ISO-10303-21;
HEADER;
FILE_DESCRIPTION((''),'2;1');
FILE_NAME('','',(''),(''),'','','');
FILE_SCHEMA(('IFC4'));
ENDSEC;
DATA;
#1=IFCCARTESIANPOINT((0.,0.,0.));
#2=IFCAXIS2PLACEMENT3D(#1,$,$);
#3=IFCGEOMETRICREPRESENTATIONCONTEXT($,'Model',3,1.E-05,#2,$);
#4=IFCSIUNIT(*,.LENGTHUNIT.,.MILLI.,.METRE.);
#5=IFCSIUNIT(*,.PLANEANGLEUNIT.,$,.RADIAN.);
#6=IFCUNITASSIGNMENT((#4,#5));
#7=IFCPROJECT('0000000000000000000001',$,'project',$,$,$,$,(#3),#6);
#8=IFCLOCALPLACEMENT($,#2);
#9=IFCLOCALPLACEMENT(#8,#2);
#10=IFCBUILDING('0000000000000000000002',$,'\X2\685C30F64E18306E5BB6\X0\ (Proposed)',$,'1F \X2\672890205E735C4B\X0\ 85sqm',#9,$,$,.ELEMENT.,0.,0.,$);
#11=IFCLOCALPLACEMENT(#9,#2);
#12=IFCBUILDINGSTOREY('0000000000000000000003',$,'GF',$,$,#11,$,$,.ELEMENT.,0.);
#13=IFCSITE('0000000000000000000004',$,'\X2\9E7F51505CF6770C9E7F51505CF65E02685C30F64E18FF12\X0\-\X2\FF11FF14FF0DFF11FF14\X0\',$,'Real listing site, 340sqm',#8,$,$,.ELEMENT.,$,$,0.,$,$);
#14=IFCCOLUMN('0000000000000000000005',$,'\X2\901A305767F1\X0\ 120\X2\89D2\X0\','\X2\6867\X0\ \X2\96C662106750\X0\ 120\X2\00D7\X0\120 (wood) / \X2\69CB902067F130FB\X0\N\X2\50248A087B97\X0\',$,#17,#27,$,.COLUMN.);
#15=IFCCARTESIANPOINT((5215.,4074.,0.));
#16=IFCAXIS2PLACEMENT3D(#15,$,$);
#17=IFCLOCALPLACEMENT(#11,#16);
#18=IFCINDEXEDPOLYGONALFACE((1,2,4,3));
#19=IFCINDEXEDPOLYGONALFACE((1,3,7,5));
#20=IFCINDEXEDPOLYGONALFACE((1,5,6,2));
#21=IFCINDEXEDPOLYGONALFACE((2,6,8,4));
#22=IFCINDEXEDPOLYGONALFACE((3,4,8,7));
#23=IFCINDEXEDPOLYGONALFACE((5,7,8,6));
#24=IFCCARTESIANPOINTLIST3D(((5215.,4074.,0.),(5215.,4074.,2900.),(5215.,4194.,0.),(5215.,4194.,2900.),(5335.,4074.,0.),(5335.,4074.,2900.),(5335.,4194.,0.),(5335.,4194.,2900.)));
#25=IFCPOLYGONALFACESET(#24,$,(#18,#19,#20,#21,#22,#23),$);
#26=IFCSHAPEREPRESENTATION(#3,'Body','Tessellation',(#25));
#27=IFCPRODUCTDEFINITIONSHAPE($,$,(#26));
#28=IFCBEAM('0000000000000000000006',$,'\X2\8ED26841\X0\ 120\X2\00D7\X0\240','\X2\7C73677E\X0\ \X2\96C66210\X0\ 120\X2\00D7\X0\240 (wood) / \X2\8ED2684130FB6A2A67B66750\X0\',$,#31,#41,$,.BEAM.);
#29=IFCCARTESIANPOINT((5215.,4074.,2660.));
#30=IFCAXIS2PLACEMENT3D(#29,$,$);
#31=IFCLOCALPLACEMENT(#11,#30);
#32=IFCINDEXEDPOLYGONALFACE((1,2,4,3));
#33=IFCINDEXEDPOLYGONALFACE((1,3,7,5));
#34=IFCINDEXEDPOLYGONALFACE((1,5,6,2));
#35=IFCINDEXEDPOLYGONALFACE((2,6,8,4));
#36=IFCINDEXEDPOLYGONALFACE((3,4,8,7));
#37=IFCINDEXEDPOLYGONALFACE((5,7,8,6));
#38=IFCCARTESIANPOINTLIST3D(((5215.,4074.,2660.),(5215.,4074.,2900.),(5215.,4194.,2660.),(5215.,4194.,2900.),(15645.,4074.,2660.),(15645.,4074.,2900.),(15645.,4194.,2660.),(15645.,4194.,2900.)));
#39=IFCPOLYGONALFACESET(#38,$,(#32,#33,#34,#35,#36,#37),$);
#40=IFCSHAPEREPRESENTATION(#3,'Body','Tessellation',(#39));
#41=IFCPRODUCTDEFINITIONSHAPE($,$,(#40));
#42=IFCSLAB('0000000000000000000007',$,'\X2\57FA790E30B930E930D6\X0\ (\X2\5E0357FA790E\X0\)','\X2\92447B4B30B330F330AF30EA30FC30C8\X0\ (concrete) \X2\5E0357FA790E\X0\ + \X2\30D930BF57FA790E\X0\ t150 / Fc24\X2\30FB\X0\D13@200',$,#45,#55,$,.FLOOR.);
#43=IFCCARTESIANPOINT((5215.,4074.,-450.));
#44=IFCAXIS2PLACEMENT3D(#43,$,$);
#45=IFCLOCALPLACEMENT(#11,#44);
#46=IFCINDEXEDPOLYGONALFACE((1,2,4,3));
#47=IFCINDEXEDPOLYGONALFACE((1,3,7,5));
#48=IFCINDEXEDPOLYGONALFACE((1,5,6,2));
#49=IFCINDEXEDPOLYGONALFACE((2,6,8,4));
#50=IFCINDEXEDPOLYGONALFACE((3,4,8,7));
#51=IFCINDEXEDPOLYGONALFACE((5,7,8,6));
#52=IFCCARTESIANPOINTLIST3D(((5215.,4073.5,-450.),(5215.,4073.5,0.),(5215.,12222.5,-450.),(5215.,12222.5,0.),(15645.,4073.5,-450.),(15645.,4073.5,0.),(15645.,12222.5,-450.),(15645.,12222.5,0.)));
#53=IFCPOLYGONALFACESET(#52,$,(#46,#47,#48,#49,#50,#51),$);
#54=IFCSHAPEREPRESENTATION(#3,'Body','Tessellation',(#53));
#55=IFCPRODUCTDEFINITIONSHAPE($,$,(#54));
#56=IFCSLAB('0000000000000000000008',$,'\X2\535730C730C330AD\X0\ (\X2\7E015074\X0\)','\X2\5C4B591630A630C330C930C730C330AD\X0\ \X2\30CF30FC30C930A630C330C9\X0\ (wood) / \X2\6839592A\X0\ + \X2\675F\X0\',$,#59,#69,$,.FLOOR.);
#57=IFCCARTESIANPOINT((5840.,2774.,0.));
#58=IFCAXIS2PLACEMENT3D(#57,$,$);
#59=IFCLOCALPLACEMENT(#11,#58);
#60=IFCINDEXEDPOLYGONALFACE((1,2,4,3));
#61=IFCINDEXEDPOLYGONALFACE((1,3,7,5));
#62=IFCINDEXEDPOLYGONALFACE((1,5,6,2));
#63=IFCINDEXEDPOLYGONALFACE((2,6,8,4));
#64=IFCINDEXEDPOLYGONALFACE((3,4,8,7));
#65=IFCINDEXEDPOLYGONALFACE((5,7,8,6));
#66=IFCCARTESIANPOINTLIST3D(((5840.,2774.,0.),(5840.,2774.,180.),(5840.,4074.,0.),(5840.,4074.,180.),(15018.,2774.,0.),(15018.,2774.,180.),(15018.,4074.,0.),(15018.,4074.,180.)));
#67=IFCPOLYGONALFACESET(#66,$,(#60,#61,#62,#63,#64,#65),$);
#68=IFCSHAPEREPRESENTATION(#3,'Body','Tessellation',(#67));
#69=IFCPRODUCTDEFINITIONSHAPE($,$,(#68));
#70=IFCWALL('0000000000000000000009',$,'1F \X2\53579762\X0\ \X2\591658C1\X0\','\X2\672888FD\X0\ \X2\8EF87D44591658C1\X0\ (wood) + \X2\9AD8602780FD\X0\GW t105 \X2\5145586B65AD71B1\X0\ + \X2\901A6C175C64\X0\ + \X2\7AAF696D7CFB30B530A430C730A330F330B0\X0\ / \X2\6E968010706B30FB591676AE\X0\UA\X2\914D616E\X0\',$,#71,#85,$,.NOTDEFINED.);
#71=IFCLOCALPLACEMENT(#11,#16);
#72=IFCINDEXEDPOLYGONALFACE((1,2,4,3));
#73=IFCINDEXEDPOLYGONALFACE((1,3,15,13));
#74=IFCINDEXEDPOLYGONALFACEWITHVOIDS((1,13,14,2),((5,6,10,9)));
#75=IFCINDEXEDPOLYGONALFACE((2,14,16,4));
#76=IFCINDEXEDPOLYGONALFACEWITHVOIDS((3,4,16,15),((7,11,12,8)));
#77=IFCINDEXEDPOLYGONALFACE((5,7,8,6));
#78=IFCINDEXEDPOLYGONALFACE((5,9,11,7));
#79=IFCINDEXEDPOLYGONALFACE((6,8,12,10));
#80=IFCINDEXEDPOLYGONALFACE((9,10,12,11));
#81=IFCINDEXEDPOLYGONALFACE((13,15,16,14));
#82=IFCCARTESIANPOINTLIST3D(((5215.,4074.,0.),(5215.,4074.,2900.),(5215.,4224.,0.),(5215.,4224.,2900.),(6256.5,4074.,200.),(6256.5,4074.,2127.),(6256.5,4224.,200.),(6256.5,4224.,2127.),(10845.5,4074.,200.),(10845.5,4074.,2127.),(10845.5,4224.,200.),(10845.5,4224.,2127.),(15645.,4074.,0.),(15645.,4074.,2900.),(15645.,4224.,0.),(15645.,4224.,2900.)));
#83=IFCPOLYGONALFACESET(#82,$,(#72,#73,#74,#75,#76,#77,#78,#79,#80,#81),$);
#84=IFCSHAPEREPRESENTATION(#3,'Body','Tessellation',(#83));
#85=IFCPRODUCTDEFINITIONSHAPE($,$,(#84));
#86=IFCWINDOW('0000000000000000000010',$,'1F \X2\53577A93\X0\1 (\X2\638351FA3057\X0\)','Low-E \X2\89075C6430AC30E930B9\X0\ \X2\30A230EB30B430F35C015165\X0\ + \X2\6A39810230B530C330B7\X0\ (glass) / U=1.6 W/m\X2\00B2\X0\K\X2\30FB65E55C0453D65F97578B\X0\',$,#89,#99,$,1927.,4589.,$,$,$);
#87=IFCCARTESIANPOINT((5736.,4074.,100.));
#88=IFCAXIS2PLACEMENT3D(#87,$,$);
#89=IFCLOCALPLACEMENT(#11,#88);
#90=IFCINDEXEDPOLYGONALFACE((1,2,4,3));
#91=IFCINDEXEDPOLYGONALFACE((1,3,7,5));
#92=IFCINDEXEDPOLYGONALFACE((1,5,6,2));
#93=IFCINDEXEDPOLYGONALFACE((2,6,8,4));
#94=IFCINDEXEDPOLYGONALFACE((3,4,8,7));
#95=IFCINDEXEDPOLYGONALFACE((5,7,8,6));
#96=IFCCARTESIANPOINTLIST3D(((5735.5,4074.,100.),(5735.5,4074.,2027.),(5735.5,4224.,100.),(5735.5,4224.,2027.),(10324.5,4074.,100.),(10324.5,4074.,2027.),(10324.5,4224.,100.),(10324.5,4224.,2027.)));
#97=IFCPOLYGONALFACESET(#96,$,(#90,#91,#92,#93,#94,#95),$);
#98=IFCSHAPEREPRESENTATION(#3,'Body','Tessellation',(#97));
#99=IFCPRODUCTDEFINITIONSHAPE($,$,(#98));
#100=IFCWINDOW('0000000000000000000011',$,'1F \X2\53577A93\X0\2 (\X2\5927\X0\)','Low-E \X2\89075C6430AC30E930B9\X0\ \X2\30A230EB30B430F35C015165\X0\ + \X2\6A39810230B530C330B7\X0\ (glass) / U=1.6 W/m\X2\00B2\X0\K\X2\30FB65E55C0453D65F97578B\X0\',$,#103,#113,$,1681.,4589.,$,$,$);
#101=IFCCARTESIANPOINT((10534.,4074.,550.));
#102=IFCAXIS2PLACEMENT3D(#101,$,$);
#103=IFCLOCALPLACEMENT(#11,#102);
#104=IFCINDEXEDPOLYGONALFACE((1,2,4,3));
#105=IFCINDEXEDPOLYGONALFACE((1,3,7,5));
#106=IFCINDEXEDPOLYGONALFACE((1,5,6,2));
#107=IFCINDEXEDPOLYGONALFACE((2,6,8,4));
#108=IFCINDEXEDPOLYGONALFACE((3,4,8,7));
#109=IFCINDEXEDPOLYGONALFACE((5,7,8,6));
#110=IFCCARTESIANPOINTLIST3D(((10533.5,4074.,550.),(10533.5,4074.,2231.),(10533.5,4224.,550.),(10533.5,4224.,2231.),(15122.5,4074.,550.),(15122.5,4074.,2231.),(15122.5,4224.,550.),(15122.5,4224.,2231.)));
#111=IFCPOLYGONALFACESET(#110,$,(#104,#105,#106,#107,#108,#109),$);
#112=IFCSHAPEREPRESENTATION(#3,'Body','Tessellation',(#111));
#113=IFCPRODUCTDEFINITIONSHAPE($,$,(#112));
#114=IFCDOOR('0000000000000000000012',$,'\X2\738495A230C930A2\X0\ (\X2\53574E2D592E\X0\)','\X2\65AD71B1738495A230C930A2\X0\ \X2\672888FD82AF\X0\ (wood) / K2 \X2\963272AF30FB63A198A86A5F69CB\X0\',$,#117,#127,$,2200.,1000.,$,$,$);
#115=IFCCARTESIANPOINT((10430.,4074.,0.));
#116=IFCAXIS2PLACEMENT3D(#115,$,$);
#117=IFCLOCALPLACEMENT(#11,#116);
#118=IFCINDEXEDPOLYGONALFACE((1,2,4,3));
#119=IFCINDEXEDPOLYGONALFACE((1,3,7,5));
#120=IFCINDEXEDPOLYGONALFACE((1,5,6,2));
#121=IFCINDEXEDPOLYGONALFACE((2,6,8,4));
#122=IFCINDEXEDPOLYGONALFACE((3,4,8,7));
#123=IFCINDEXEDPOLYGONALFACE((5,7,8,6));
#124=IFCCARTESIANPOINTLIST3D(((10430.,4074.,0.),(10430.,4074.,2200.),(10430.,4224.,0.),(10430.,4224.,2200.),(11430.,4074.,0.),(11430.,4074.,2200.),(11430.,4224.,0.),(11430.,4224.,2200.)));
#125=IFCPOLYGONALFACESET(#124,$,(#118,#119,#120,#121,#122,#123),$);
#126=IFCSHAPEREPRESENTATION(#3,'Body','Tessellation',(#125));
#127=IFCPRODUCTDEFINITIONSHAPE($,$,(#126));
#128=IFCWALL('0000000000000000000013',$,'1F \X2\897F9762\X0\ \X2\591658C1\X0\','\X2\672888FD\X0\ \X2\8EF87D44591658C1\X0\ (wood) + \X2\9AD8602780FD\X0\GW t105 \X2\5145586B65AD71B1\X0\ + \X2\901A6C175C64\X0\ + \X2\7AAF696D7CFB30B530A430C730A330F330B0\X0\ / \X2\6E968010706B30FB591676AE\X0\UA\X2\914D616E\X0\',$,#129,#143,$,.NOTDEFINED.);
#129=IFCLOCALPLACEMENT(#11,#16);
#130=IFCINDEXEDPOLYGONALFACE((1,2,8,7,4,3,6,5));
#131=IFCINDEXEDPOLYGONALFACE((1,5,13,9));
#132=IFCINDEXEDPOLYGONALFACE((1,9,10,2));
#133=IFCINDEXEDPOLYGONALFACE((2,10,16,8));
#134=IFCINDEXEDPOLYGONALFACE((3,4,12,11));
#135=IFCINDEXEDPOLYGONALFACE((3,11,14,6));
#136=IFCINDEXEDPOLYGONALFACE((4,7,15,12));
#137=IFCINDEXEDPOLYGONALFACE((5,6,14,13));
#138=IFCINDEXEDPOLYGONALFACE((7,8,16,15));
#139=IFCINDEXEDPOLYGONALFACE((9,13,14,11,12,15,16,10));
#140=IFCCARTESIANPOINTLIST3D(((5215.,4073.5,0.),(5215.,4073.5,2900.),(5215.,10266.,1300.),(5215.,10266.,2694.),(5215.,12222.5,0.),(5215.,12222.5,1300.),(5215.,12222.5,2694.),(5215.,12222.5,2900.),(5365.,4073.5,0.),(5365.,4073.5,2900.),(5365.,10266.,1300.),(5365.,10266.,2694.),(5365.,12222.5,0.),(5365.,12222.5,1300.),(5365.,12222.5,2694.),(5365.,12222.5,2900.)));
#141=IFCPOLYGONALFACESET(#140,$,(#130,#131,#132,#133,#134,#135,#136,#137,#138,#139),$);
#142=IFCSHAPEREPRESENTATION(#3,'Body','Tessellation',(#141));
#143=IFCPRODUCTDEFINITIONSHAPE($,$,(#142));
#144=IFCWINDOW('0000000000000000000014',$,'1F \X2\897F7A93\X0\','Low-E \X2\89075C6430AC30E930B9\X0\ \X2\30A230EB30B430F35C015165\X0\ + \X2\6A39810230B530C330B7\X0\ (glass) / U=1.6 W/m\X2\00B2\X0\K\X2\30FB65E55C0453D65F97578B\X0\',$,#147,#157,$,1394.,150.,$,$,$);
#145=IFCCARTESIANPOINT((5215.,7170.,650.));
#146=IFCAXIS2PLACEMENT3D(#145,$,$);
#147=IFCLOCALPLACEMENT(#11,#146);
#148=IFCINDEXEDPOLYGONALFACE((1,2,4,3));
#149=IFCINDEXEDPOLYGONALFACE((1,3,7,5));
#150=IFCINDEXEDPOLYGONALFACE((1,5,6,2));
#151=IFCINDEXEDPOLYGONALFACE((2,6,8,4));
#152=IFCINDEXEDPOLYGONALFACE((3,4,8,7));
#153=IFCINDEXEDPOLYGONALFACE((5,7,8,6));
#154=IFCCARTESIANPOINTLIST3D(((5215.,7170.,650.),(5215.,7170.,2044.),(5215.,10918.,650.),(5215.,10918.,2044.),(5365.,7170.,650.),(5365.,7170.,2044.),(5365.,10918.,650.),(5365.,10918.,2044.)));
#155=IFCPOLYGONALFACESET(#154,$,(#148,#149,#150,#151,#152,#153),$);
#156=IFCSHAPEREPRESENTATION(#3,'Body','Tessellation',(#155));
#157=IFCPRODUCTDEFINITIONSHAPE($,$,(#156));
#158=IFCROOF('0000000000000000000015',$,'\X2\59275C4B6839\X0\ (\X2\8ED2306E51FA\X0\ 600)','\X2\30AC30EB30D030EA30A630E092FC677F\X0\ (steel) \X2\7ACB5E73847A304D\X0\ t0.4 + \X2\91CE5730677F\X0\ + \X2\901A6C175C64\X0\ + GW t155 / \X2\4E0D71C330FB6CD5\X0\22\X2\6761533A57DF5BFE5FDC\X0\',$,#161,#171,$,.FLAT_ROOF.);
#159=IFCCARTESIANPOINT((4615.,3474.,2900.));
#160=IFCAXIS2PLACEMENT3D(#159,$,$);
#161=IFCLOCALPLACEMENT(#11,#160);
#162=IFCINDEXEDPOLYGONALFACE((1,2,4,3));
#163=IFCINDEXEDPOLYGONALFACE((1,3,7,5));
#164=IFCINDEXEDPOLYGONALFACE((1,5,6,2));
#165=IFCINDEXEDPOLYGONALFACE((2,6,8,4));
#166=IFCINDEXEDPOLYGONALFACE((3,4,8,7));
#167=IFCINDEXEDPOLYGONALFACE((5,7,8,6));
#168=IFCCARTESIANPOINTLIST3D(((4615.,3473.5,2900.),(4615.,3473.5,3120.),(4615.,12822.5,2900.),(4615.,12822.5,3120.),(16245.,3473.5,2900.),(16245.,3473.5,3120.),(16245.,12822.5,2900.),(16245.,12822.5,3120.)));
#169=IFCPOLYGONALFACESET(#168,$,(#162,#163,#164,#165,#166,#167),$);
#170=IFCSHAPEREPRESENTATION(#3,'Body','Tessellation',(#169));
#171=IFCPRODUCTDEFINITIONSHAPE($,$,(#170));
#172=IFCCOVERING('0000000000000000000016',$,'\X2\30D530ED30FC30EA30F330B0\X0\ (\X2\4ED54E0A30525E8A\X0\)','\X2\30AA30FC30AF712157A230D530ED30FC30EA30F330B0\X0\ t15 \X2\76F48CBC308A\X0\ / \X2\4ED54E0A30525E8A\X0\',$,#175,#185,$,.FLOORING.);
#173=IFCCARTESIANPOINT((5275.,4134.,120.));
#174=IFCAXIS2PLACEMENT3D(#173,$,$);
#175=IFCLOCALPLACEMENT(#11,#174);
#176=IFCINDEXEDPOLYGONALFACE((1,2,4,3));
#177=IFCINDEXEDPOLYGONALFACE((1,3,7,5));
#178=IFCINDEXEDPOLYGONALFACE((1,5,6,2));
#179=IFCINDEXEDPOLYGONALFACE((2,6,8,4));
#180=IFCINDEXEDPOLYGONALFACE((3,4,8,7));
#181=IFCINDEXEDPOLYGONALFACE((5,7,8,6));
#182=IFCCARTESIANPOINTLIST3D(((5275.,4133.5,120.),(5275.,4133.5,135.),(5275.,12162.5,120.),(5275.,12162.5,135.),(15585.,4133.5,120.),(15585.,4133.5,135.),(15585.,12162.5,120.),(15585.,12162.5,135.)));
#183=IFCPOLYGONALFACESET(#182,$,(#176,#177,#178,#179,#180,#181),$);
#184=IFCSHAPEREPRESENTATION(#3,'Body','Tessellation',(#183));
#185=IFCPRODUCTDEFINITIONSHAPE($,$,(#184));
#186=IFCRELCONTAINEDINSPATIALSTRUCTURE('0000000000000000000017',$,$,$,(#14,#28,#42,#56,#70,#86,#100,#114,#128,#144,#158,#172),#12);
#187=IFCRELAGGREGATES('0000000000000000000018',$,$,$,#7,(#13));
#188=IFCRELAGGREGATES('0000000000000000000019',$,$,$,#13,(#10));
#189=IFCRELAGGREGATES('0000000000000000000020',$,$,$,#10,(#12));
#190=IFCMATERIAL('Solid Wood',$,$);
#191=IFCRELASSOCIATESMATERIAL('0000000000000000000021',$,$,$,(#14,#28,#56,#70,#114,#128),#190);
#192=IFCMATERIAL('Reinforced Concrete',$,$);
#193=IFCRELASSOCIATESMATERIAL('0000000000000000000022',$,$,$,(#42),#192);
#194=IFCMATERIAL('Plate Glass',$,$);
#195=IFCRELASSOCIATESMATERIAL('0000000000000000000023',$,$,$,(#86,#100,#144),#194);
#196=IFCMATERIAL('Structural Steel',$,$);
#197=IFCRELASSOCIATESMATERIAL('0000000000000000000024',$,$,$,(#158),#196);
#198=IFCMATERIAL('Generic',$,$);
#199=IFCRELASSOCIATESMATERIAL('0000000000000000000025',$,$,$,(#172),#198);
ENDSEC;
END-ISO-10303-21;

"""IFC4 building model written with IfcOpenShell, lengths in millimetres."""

from ifc_helpers import new_model, si_unit, frame, frame_2d, origin, place, context, project, spatial, rectangle, extrude, material, element, fill, save


model = new_model("IFC4")

# Units and contexts
model_context = context("Model", 3, precision=1e-05, world=origin())
ifc_project = project(units=[si_unit("LENGTHUNIT", "METRE", prefix="MILLI"), si_unit("PLANEANGLEUNIT", "RADIAN")], contexts=[model_context])

# Site, building, storey
site_placement = place(None, origin())
site = spatial("IfcSite", under=ifc_project, at=site_placement, Name="鹿児島県鹿児島市桜ヶ丘２-１４－１４", ObjectType="Real listing site, 340sqm", CompositionType="ELEMENT", RefElevation=0.0)
building_placement = place(site_placement, origin())
building = spatial("IfcBuilding", under=site, at=building_placement, Name="桜ヶ丘の家 (Proposed)", ObjectType="1F 木造平屋 85sqm", CompositionType="ELEMENT", ElevationOfRefHeight=0.0, ElevationOfTerrain=0.0)
storey_placement = place(building_placement, origin())
storey = spatial("IfcBuildingStorey", under=building, at=storey_placement, Name="GF", CompositionType="ELEMENT", Elevation=0.0)

# Column
ifc_material_1 = material(Name="Solid Wood")
column_1_placement = place(storey_placement, frame((5215.0, 4074.0, 0.0)))
element("IfcColumn", 1, at=column_1_placement, inside=storey, material=ifc_material_1, Name="通し柱 120角", Description="桧 集成材 120×120 (wood) / 構造柱・N値計算", PredefinedType="COLUMN", context=model_context, shape_type="SweptSolid", body=[
    extrude(rectangle(XDim=120.0, YDim=120.0, at=frame_2d((60.0, 60.0))), frame((5215.0, 4074.0, 0.0)), (0.0, 0.0, 1.0), 2900.0),
])

# Beam
beam_1_placement = place(storey_placement, frame((5215.0, 4074.0, 2660.0)))
element("IfcBeam", 2, at=beam_1_placement, inside=storey, material=ifc_material_1, Name="軒桁 120×240", Description="米松 集成 120×240 (wood) / 軒桁・横架材", PredefinedType="BEAM", context=model_context, shape_type="SweptSolid", body=[
    extrude(rectangle(XDim=10430.0, YDim=120.0, at=frame_2d((5215.0, 60.0))), frame((5215.0, 4074.0, 2660.0)), (0.0, 0.0, 1.0), 240.0),
])

# Slabs
ifc_material_2 = material(Name="Reinforced Concrete")
slab_1_placement = place(storey_placement, frame((5215.0, 4074.0, -450.0)))
element("IfcSlab", 3, at=slab_1_placement, inside=storey, material=ifc_material_2, Name="基礎スラブ (布基礎)", Description="鉄筋コンクリート (concrete) 布基礎 + ベタ基礎 t150 / Fc24・D13@200", PredefinedType="FLOOR", context=model_context, shape_type="SweptSolid", body=[
    extrude(rectangle(XDim=10430.0, YDim=8149.0, at=frame_2d((5215.0, 4074.0))), frame((5215.0, 4074.0, -450.0)), (0.0, 0.0, 1.0), 450.0),
])
slab_2_placement = place(storey_placement, frame((5840.0, 2774.0, 0.0)))
element("IfcSlab", 4, at=slab_2_placement, inside=storey, material=ifc_material_1, Name="南デッキ (縁側)", Description="屋外ウッドデッキ ハードウッド (wood) / 根太 + 束", PredefinedType="FLOOR", context=model_context, shape_type="SweptSolid", body=[
    extrude(rectangle(XDim=9178.0, YDim=1300.0, at=frame_2d((4589.0, 650.0))), frame((5840.0, 2774.0, 0.0)), (0.0, 0.0, 1.0), 180.0),
])

# Wall, openings, windows, door
wall_1_placement = place(storey_placement, frame((5215.0, 4074.0, 0.0)))
wall_1 = element("IfcWall", 5, at=wall_1_placement, inside=storey, material=ifc_material_1, Name="1F 南面 外壁", Description="木製 軸組外壁 (wood) + 高性能GW t105 充填断熱 + 通気層 + 窯業系サイディング / 準耐火・外皮UA配慮", PredefinedType="NOTDEFINED", context=model_context, shape_type="SweptSolid", body=[
    extrude(rectangle(XDim=10430.0, YDim=150.0, at=frame_2d((5215.0, 75.0))), frame((5215.0, 4074.0, 0.0)), (0.0, 0.0, 1.0), 2900.0),
])
opening_1_placement = place(storey_placement, frame((5736.0, 4074.0, 100.0)))
opening_1 = element("IfcOpeningElement", 6, at=opening_1_placement, cuts=wall_1, PredefinedType="NOTDEFINED", context=model_context, shape_type="SweptSolid", body=[
    extrude(rectangle(XDim=4589.0, YDim=150.0, at=frame_2d((2294.0, 75.0))), frame((5736.0, 4074.0, 100.0)), (0.0, 0.0, 1.0), 1927.0),
])
opening_2_placement = place(storey_placement, frame((10534.0, 4074.0, 550.0)))
opening_2 = element("IfcOpeningElement", 7, at=opening_2_placement, cuts=wall_1, PredefinedType="NOTDEFINED", context=model_context, shape_type="SweptSolid", body=[
    extrude(rectangle(XDim=4589.0, YDim=150.0, at=frame_2d((2294.0, 75.0))), frame((10534.0, 4074.0, 550.0)), (0.0, 0.0, 1.0), 1681.0),
])
opening_3_placement = place(storey_placement, frame((10430.0, 4074.0, 0.0)))
opening_3 = element("IfcOpeningElement", 8, at=opening_3_placement, cuts=wall_1, PredefinedType="NOTDEFINED", context=model_context, shape_type="SweptSolid", body=[
    extrude(rectangle(XDim=1000.0, YDim=150.0, at=frame_2d((500.0, 75.0))), frame((10430.0, 4074.0, 0.0)), (0.0, 0.0, 1.0), 2200.0),
])
ifc_material_3 = material(Name="Plate Glass")
window_1_placement = place(storey_placement, frame((5736.0, 4074.0, 100.0)))
window_1 = element("IfcWindow", 9, at=window_1_placement, inside=storey, material=ifc_material_3, Name="1F 南窓1 (掃出し)", Description="Low-E 複層ガラス アルゴン封入 + 樹脂サッシ (glass) / U=1.6 W/m²K・日射取得型", OverallHeight=1927.0, OverallWidth=4589.0, context=model_context, shape_type="SweptSolid", body=[
    extrude(rectangle(XDim=4589.0, YDim=150.0, at=frame_2d((2294.0, 75.0))), frame((5736.0, 4074.0, 100.0)), (0.0, 0.0, 1.0), 1927.0),
])
fill(opening_1, window_1)
window_2_placement = place(storey_placement, frame((10534.0, 4074.0, 550.0)))
window_2 = element("IfcWindow", 10, at=window_2_placement, inside=storey, material=ifc_material_3, Name="1F 南窓2 (大)", Description="Low-E 複層ガラス アルゴン封入 + 樹脂サッシ (glass) / U=1.6 W/m²K・日射取得型", OverallHeight=1681.0, OverallWidth=4589.0, context=model_context, shape_type="SweptSolid", body=[
    extrude(rectangle(XDim=4589.0, YDim=150.0, at=frame_2d((2294.0, 75.0))), frame((10534.0, 4074.0, 550.0)), (0.0, 0.0, 1.0), 1681.0),
])
fill(opening_2, window_2)
door_placement = place(storey_placement, frame((10430.0, 4074.0, 0.0)))
door = element("IfcDoor", 11, at=door_placement, inside=storey, material=ifc_material_1, Name="玄関ドア (南中央)", Description="断熱玄関ドア 木製芯 (wood) / K2 防犯・採風機構", OverallHeight=2200.0, OverallWidth=1000.0, context=model_context, shape_type="SweptSolid", body=[
    extrude(rectangle(XDim=1000.0, YDim=150.0, at=frame_2d((500.0, 75.0))), frame((10430.0, 4074.0, 0.0)), (0.0, 0.0, 1.0), 2200.0),
])
fill(opening_3, door)

# Wall, opening, window
wall_2_placement = place(storey_placement, frame((5215.0, 4074.0, 0.0)))
wall_2 = element("IfcWall", 12, at=wall_2_placement, inside=storey, material=ifc_material_1, Name="1F 西面 外壁", Description="木製 軸組外壁 (wood) + 高性能GW t105 充填断熱 + 通気層 + 窯業系サイディング / 準耐火・外皮UA配慮", PredefinedType="NOTDEFINED", context=model_context, shape_type="SweptSolid", body=[
    extrude(rectangle(XDim=150.0, YDim=8149.0, at=frame_2d((75.0, 4074.0))), frame((5215.0, 4074.0, 0.0)), (0.0, 0.0, 1.0), 2900.0),
])
opening_4_placement = place(storey_placement, frame((5215.0, 7170.0, 650.0)))
opening_4 = element("IfcOpeningElement", 13, at=opening_4_placement, cuts=wall_2, PredefinedType="NOTDEFINED", context=model_context, shape_type="SweptSolid", body=[
    extrude(rectangle(XDim=150.0, YDim=3748.0, at=frame_2d((75.0, 1874.0))), frame((5215.0, 7170.0, 650.0)), (0.0, 0.0, 1.0), 1394.0),
])
window_3_placement = place(storey_placement, frame((5215.0, 7170.0, 650.0)))
window_3 = element("IfcWindow", 14, at=window_3_placement, inside=storey, material=ifc_material_3, Name="1F 西窓", Description="Low-E 複層ガラス アルゴン封入 + 樹脂サッシ (glass) / U=1.6 W/m²K・日射取得型", OverallHeight=1394.0, OverallWidth=150.0, context=model_context, shape_type="SweptSolid", body=[
    extrude(rectangle(XDim=150.0, YDim=3748.0, at=frame_2d((75.0, 1874.0))), frame((5215.0, 7170.0, 650.0)), (0.0, 0.0, 1.0), 1394.0),
])
fill(opening_4, window_3)

# Roof
ifc_material_4 = material(Name="Structural Steel")
roof_placement = place(storey_placement, frame((4615.0, 3474.0, 2900.0)))
element("IfcRoof", 15, at=roof_placement, inside=storey, material=ifc_material_4, Name="大屋根 (軒の出 600)", Description="ガルバリウム鋼板 (steel) 立平葺き t0.4 + 野地板 + 通気層 + GW t155 / 不燃・法22条区域対応", PredefinedType="FLAT_ROOF", context=model_context, shape_type="SweptSolid", body=[
    extrude(rectangle(XDim=11630.0, YDim=9349.0, at=frame_2d((5815.0, 4674.0))), frame((4615.0, 3474.0, 2900.0)), (0.0, 0.0, 1.0), 220.0),
])

# Covering
ifc_material_5 = material(Name="Generic")
covering_1_placement = place(storey_placement, frame((5275.0, 4134.0, 120.0)))
element("IfcCovering", 16, at=covering_1_placement, inside=storey, material=ifc_material_5, Name="フローリング (仕上げ床)", Description="オーク無垢フローリング t15 直貼り / 仕上げ床", PredefinedType="FLOORING", context=model_context, shape_type="SweptSolid", body=[
    extrude(rectangle(XDim=10310.0, YDim=8029.0, at=frame_2d((5155.0, 4014.0))), frame((5275.0, 4134.0, 120.0)), (0.0, 0.0, 1.0), 15.0),
])

save(model, "model.ifc")
